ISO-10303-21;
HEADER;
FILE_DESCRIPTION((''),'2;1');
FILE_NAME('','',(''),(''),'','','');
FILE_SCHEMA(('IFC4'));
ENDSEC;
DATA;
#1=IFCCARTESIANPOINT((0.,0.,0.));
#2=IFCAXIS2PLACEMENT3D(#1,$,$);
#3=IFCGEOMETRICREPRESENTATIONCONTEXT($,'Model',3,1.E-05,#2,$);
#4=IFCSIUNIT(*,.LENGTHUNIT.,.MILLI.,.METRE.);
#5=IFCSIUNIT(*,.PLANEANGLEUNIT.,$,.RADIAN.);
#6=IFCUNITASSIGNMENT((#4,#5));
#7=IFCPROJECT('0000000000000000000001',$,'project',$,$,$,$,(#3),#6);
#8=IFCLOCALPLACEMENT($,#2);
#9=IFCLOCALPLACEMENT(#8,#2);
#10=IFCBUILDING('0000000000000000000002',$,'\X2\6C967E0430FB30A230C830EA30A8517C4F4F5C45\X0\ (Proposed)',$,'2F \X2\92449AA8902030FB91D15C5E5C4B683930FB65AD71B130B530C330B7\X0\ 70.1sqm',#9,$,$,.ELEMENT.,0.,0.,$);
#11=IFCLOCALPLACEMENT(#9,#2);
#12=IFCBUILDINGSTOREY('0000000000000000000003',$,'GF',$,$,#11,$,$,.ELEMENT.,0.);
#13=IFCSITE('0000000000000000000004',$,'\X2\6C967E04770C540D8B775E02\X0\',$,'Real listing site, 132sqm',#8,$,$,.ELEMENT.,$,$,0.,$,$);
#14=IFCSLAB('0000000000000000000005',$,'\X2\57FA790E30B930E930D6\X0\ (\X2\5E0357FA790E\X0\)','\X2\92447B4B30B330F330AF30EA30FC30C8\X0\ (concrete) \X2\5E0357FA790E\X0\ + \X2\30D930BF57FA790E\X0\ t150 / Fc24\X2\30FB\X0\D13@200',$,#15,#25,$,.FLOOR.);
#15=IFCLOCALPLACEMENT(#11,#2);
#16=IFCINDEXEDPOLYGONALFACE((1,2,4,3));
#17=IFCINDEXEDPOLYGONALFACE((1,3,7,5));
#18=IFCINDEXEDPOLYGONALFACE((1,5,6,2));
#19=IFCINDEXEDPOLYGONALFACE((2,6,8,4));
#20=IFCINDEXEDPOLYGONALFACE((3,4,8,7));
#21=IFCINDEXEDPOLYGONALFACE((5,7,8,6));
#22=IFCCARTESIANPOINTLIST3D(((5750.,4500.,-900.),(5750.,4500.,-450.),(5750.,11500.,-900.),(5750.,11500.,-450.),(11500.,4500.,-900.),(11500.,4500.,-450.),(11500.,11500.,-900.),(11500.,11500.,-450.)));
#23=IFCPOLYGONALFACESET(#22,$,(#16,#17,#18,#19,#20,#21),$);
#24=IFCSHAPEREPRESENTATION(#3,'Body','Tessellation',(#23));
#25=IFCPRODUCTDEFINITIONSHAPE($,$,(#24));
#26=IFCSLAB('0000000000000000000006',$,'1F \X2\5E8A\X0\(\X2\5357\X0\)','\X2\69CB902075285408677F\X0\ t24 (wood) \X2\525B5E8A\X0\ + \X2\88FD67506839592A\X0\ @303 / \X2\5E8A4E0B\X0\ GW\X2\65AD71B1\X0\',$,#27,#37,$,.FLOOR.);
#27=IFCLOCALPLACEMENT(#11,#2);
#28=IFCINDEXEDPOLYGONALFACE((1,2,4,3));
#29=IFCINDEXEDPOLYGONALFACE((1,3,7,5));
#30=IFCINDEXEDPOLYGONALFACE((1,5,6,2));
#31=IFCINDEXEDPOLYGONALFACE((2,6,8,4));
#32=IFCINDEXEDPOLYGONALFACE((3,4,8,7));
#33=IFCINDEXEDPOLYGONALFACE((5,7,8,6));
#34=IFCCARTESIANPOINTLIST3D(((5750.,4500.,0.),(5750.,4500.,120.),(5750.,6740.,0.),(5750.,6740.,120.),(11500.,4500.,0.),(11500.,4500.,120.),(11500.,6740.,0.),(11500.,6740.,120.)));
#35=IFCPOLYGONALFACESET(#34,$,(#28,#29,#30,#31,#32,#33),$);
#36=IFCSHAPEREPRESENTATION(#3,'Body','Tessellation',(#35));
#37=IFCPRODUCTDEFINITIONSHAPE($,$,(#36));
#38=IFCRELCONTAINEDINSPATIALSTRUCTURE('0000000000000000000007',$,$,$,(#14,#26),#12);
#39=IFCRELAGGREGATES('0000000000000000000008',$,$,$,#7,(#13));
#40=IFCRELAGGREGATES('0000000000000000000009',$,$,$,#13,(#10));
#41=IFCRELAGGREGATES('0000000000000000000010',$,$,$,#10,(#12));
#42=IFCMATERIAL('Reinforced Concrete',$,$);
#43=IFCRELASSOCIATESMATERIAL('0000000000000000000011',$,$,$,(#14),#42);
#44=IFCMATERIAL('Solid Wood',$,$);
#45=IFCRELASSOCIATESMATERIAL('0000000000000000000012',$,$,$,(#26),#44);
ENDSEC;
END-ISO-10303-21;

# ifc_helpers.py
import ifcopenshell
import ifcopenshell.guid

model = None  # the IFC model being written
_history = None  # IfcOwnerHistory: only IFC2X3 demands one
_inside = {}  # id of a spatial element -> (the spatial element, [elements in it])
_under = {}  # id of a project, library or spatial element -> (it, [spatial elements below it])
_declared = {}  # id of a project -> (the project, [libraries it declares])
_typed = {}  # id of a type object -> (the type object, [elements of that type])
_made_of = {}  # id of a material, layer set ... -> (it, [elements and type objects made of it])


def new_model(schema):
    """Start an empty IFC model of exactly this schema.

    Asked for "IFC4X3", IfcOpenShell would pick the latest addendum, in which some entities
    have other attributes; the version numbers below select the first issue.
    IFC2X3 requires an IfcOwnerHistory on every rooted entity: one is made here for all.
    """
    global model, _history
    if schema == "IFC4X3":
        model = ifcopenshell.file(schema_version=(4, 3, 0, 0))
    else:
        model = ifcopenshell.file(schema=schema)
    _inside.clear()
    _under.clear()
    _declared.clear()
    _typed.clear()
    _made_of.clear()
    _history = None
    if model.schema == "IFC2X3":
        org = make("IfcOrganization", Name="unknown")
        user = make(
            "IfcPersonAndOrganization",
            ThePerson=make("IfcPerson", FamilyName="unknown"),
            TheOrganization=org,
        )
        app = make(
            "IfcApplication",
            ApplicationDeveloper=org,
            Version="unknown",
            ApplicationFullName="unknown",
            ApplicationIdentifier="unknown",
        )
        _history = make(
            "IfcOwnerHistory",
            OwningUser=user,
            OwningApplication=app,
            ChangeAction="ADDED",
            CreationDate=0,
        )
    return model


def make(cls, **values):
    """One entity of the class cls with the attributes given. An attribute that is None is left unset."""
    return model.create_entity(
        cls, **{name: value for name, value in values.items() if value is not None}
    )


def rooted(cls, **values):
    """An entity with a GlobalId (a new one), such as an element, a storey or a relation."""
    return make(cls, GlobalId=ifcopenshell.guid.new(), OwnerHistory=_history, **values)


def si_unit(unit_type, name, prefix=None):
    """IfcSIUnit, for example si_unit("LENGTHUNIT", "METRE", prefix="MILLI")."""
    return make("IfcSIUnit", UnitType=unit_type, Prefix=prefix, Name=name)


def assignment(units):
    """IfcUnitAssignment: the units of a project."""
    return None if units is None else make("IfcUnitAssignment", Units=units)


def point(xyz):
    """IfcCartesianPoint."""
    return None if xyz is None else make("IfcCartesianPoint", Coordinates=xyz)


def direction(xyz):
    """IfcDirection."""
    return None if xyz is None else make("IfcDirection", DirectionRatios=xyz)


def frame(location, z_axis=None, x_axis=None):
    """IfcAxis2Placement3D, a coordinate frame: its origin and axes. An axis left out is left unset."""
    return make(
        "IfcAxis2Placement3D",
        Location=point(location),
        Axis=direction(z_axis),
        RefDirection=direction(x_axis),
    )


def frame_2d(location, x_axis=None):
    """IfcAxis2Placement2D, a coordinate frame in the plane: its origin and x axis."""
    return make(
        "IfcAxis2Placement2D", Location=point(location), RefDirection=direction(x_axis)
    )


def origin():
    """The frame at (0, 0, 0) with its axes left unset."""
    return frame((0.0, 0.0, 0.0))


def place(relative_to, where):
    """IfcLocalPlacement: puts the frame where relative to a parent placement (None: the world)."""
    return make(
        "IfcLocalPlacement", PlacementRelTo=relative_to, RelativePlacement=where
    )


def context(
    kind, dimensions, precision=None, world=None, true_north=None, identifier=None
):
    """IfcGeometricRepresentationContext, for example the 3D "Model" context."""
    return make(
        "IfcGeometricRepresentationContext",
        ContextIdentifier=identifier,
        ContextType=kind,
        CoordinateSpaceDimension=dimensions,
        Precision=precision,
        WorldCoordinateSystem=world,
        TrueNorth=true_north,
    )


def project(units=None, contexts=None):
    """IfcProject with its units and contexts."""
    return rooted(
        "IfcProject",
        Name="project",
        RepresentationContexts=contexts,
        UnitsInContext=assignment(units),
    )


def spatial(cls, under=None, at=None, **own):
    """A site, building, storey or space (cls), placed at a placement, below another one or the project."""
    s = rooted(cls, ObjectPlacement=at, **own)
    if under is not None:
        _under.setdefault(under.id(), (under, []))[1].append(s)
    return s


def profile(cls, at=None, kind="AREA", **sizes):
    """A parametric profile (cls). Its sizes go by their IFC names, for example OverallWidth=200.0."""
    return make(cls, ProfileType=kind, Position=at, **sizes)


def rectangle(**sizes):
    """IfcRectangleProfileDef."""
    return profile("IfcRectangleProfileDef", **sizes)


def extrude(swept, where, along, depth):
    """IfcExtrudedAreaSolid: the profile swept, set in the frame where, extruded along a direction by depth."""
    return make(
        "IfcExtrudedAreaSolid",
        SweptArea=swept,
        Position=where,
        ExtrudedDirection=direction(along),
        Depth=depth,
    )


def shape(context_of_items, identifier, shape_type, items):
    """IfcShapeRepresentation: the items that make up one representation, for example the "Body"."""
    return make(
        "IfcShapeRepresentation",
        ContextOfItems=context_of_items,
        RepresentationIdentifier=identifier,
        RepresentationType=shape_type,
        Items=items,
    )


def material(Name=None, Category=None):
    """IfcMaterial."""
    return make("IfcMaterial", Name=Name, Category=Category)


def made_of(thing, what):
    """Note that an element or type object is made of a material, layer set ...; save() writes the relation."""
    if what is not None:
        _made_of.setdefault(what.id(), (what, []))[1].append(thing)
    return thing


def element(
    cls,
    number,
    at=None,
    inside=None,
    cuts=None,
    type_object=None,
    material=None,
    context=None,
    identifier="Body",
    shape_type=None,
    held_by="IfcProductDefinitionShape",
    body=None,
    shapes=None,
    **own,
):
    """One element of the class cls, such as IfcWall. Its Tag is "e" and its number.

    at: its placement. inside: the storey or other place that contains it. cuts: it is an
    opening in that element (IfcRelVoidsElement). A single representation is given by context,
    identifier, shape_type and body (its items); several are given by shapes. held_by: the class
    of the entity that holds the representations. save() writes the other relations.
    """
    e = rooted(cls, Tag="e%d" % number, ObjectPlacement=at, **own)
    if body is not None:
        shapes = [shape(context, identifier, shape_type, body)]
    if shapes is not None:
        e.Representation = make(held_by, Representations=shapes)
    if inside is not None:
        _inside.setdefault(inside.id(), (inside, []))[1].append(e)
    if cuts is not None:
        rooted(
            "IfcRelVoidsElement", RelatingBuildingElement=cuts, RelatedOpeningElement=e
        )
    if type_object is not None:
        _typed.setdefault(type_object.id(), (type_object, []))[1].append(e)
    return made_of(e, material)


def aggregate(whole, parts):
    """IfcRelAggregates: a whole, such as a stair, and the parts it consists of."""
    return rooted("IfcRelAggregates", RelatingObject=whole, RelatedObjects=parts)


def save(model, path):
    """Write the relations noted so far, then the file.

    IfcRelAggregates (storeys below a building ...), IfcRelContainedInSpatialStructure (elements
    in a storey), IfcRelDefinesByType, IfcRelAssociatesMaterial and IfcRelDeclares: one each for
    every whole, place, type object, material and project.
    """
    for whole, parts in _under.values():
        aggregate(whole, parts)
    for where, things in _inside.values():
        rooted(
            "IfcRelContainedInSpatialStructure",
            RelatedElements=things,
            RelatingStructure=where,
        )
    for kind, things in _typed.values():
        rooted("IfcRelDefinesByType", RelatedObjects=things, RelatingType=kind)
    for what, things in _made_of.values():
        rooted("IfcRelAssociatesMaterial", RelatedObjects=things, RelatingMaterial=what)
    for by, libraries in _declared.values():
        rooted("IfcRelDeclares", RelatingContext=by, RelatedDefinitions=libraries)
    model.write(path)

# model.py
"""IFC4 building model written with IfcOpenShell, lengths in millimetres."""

from ifc_helpers import new_model, si_unit, frame, frame_2d, origin, place, context, project, spatial, rectangle, extrude, material, element, save


model = new_model("IFC4")

# Units and contexts
model_context = context("Model", 3, precision=1e-05, world=origin())
ifc_project = project(units=[si_unit("LENGTHUNIT", "METRE", prefix="MILLI"), si_unit("PLANEANGLEUNIT", "RADIAN")], contexts=[model_context])

# Site, building, storey
site_placement = place(None, origin())
site = spatial("IfcSite", under=ifc_project, at=site_placement, Name="沖縄県名護市", ObjectType="Real listing site, 132sqm", CompositionType="ELEMENT", RefElevation=0.0)
building_placement = place(site_placement, origin())
building = spatial("IfcBuilding", under=site, at=building_placement, Name="沖縄・アトリエ兼住居 (Proposed)", ObjectType="2F 鉄骨造・金属屋根・断熱サッシ 70.1sqm", CompositionType="ELEMENT", ElevationOfRefHeight=0.0, ElevationOfTerrain=0.0)
storey_placement = place(building_placement, origin())
storey = spatial("IfcBuildingStorey", under=building, at=storey_placement, Name="GF", CompositionType="ELEMENT", Elevation=0.0)

# Shared definitions
ifc_material_1 = material(Name="Solid Wood")

# Slabs
ifc_material_2 = material(Name="Reinforced Concrete")
slab_1_placement = place(storey_placement, frame((2875.0, 2250.0, -450.0)))
element("IfcSlab", 1, at=slab_1_placement, inside=storey, material=ifc_material_2, Name="基礎スラブ (布基礎)", Description="鉄筋コンクリート (concrete) 布基礎 + ベタ基礎 t150 / Fc24・D13@200", PredefinedType="FLOOR", context=model_context, shape_type="SweptSolid", body=[
    extrude(rectangle(XDim=5750.0, YDim=7000.0, at=frame_2d((2875.0, 3500.0))), frame((2875.0, 2250.0, -450.0)), (0.0, 0.0, 1.0), 450.0),
])
slab_2_placement = place(storey_placement, frame((2875.0, 2250.0, 0.0)))
element("IfcSlab", 2, at=slab_2_placement, inside=storey, material=ifc_material_1, Name="1F 床(南)", Description="構造用合板 t24 (wood) 剛床 + 製材根太 @303 / 床下 GW断熱", PredefinedType="FLOOR", context=model_context, shape_type="SweptSolid", body=[
    extrude(rectangle(XDim=5750.0, YDim=2240.0, at=frame_2d((2875.0, 1120.0))), frame((2875.0, 2250.0, 0.0)), (0.0, 0.0, 1.0), 120.0),
])

save(model, "model.ifc")
